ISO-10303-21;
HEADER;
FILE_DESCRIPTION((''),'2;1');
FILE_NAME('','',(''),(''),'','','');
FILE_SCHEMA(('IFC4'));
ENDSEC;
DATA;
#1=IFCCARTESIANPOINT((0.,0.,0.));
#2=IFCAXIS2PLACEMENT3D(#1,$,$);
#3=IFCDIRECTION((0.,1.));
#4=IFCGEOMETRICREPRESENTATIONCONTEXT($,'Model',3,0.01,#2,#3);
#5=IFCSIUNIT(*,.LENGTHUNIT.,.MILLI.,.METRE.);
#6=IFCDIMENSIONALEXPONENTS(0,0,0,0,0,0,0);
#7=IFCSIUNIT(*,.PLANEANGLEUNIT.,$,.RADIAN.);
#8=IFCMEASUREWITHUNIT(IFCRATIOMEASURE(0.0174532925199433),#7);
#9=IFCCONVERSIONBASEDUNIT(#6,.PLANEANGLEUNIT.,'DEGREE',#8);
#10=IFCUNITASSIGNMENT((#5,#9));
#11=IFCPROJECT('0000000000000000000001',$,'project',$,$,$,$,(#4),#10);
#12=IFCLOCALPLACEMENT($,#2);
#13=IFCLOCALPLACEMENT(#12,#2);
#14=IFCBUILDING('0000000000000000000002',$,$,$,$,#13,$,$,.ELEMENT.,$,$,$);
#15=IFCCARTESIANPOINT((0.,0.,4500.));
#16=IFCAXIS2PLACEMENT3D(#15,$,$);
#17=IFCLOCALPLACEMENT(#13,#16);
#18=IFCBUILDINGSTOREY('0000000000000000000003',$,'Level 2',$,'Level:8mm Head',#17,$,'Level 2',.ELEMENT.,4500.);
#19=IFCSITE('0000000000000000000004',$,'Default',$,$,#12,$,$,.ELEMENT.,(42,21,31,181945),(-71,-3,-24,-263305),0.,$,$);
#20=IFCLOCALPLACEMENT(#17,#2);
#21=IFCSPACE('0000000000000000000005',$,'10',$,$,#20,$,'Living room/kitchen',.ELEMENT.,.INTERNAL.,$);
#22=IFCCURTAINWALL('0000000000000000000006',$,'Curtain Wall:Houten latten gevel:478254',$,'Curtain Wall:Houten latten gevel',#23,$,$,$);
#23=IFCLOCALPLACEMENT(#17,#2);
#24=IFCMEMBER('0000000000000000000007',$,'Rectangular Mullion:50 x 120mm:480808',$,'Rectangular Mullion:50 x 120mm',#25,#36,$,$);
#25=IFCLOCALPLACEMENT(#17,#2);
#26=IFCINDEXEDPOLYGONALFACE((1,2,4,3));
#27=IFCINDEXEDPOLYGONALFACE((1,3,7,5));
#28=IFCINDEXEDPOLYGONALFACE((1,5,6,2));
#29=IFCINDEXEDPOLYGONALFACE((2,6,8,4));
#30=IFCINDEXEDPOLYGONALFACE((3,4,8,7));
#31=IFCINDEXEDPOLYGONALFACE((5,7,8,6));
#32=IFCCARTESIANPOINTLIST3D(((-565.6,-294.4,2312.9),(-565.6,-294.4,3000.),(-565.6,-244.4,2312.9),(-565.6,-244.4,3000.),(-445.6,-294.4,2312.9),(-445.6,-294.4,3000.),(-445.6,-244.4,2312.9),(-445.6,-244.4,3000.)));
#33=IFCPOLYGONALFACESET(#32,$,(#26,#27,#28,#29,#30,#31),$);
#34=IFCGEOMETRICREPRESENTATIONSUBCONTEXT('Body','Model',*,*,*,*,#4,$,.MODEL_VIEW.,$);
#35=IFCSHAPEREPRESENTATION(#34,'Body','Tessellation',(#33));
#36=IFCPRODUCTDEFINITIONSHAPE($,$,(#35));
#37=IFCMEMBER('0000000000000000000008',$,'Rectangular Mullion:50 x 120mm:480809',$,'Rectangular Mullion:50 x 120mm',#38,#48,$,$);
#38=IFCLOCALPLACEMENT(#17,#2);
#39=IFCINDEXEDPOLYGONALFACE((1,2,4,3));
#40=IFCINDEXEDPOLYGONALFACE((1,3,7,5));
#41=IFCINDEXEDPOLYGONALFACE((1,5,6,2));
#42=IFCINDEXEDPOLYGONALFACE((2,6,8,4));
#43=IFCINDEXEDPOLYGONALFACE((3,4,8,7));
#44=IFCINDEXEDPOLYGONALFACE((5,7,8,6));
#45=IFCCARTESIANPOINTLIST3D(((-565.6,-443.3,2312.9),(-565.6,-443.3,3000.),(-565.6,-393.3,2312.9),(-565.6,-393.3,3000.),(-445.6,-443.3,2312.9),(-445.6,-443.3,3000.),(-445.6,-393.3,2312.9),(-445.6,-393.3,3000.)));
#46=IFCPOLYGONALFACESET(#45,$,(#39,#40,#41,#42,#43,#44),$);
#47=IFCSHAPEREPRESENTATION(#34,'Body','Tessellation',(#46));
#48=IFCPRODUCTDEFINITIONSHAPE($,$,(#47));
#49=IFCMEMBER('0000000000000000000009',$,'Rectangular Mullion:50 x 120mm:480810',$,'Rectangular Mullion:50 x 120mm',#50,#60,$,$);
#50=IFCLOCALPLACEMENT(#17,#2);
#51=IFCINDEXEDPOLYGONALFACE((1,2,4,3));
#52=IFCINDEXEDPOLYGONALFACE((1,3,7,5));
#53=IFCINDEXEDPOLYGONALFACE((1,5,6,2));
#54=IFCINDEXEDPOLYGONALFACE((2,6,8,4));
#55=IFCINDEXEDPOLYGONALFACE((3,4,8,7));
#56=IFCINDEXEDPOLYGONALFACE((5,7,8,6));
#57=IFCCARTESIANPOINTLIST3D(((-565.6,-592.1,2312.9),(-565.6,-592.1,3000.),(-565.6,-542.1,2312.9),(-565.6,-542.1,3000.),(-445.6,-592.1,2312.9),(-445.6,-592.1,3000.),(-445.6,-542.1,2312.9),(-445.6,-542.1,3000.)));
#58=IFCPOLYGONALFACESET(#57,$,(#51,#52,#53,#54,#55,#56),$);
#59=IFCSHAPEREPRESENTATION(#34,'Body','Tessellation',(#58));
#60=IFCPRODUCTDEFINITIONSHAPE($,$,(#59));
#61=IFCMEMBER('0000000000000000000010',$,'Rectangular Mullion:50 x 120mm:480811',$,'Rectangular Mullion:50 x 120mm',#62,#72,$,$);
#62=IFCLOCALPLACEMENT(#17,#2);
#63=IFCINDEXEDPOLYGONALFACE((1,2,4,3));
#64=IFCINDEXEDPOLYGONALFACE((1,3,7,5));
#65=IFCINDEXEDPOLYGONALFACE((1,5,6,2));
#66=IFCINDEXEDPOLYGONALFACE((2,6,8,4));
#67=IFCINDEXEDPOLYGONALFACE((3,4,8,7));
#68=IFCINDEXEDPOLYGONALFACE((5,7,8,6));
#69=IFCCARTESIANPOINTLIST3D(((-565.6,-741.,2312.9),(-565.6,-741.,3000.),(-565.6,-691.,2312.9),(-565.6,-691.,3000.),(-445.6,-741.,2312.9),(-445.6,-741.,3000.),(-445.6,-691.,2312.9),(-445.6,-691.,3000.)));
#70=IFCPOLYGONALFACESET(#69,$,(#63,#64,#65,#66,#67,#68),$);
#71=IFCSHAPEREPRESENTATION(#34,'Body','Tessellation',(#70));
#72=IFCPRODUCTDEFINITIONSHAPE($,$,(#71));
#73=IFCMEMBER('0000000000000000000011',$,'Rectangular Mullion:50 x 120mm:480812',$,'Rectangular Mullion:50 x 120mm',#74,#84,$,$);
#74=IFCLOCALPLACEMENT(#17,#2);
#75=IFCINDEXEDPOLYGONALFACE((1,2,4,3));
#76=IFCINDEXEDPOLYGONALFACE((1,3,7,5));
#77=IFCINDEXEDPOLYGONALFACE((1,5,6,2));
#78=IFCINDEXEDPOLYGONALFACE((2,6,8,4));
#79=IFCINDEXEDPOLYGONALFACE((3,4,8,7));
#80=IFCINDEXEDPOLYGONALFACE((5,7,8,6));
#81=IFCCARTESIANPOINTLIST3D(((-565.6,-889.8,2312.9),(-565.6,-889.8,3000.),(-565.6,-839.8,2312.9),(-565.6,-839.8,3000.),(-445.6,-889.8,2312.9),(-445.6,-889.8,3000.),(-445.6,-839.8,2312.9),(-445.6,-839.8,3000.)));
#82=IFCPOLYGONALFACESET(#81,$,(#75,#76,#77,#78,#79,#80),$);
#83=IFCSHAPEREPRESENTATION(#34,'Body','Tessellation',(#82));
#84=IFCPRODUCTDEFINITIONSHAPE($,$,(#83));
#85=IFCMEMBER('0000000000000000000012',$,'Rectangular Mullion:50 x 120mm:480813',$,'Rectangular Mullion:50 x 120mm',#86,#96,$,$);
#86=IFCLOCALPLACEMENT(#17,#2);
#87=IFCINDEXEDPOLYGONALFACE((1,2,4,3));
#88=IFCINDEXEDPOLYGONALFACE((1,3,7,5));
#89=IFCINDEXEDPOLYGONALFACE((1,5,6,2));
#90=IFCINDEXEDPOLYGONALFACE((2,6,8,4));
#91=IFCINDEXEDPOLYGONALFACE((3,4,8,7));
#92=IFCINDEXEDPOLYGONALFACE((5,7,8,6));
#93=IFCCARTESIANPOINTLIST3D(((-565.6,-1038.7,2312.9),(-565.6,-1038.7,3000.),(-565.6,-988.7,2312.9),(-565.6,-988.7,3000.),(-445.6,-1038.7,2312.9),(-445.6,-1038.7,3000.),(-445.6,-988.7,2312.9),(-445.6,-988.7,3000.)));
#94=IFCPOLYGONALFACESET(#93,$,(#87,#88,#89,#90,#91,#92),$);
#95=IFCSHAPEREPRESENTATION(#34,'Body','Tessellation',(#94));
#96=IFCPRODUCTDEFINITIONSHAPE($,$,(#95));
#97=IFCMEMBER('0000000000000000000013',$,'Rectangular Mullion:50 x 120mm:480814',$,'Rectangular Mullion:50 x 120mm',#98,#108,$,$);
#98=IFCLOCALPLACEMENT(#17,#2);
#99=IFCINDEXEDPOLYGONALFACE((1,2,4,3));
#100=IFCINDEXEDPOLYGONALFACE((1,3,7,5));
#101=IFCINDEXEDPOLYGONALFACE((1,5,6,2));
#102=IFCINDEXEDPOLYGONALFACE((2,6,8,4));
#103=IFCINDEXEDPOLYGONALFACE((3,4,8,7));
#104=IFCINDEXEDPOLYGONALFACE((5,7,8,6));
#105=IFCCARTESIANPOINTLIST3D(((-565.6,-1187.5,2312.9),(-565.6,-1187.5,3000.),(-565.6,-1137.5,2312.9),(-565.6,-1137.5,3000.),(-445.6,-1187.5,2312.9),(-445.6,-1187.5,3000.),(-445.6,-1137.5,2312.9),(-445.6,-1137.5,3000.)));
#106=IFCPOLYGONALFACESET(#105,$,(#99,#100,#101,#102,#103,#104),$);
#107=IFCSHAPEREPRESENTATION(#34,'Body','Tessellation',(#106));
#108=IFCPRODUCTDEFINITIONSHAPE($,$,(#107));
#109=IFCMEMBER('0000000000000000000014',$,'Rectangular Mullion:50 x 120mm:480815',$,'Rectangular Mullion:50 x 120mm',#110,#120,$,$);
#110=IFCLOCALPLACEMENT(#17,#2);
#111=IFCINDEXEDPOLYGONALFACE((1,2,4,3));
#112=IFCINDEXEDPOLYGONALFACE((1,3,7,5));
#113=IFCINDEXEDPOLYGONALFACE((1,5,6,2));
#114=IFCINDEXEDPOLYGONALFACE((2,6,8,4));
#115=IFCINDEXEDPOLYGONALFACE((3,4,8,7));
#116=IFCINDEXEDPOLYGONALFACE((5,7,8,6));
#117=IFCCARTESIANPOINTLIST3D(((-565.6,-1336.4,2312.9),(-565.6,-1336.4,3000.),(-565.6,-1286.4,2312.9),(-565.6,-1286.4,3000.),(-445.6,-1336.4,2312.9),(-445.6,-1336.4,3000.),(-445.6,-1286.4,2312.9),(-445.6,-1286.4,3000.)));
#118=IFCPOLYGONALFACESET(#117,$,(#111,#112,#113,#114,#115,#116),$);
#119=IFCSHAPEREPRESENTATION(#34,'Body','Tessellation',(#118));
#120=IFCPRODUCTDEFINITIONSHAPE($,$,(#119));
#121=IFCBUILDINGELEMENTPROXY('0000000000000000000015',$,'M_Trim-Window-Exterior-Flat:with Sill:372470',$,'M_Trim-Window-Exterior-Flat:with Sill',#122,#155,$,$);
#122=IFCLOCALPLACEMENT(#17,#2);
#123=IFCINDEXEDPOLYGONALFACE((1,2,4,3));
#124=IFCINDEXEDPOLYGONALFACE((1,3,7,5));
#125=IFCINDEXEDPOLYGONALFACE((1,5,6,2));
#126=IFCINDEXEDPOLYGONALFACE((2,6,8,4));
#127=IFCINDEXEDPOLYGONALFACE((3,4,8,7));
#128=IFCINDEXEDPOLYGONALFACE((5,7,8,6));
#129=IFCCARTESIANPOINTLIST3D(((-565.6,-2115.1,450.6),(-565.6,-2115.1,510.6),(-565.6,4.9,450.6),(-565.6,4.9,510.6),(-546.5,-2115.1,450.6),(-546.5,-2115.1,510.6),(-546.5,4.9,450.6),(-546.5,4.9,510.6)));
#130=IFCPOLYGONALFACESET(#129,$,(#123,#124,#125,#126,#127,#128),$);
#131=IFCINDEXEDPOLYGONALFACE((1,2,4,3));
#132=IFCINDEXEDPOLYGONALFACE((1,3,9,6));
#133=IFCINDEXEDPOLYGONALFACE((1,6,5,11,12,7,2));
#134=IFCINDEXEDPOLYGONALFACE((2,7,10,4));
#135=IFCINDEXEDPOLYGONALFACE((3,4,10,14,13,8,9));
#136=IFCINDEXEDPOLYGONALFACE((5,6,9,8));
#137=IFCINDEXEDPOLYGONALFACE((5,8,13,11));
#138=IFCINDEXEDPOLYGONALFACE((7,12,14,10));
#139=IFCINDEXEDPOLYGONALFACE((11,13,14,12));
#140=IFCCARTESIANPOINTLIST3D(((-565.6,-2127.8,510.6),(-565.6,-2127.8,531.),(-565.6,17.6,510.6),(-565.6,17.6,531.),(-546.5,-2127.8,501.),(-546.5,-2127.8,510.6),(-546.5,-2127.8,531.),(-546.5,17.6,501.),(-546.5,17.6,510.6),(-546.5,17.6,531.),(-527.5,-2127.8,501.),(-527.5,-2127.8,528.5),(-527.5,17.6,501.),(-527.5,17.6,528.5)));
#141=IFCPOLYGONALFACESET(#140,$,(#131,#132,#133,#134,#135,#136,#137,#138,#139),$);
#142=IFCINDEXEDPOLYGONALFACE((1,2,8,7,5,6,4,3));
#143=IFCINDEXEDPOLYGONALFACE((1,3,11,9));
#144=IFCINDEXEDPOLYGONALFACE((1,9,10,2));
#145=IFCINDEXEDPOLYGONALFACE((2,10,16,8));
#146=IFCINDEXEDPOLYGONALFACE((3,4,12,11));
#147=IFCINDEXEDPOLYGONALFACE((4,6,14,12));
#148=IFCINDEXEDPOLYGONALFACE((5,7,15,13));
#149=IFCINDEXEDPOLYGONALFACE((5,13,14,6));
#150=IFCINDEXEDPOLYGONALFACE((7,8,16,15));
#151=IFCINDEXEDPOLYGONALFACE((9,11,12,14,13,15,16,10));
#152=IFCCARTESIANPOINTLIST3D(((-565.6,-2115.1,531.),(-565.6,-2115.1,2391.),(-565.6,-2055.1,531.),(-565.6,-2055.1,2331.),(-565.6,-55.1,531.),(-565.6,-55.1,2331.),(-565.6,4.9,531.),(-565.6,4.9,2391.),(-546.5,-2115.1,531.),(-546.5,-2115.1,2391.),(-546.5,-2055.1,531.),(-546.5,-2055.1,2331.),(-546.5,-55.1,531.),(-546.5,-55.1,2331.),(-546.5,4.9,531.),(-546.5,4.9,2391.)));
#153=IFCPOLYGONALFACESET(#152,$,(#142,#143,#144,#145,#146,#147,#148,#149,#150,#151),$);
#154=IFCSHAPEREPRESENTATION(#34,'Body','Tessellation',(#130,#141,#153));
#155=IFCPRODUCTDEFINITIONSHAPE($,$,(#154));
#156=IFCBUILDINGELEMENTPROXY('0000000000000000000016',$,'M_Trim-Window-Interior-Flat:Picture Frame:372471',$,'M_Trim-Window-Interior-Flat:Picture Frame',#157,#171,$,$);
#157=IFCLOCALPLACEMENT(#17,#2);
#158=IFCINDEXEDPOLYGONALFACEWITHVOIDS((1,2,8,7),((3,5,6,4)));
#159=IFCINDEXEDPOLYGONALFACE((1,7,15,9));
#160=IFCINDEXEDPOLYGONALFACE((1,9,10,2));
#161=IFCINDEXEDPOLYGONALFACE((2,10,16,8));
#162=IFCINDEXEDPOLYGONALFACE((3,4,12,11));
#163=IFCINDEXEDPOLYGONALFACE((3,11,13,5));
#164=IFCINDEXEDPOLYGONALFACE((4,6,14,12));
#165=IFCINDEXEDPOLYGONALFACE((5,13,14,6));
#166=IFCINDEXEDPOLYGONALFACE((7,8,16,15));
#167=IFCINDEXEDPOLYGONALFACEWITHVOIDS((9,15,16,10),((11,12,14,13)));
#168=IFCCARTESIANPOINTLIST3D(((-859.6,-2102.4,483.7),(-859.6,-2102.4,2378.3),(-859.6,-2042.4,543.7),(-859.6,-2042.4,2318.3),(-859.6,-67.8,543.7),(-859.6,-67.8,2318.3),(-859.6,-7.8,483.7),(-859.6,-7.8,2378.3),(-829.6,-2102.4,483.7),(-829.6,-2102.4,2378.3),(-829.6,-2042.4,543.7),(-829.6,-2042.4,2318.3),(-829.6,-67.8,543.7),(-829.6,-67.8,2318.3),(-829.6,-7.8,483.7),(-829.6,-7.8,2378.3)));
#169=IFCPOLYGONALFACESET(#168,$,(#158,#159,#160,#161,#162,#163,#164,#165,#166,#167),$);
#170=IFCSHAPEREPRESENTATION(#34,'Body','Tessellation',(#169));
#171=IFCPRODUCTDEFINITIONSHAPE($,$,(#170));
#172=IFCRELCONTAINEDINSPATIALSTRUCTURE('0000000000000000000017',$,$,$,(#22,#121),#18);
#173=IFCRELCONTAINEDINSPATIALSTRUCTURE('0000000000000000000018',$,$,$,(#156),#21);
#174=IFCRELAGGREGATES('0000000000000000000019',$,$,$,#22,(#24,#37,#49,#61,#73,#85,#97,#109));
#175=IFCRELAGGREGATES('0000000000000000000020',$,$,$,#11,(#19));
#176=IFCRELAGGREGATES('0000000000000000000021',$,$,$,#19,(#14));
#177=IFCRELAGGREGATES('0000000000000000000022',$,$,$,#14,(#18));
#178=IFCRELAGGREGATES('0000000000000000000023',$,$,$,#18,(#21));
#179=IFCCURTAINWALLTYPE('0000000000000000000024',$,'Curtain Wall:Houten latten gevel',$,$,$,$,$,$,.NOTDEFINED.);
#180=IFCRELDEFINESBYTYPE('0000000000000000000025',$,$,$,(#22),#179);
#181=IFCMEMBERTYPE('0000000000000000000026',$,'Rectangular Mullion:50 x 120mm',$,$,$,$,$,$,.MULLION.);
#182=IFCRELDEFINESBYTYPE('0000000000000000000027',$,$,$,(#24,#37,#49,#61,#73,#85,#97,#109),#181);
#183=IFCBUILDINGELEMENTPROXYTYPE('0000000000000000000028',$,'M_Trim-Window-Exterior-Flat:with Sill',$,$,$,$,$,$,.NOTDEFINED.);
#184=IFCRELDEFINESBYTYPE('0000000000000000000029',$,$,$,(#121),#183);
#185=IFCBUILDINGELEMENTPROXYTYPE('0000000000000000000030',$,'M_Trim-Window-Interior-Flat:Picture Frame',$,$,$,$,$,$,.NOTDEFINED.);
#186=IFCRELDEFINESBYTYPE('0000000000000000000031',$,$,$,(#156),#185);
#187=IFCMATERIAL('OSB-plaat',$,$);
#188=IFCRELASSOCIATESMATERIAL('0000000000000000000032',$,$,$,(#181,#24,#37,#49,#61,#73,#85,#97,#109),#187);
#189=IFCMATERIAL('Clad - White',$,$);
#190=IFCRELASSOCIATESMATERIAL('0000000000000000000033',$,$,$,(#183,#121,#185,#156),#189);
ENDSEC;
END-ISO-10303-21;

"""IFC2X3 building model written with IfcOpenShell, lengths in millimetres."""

from ifc_helpers import new_model, entity, si_unit, converted_unit, direction, frame, frame_2d, origin, origin_2d_with_axis, place, context, subcontext, project, spatial, polyline, rectangle, outline, extrude, source, transform, mapped, material, type_object, type_shapes, element, aggregate, save


model = new_model("IFC2X3")

# Units and contexts
model_context = context("Model", 3, precision=0.01, world=origin(), true_north=direction((0.0, 1.0)))
body_context = subcontext(model_context, "Body", "Model", "MODEL_VIEW")
ifc_project = project(units=[si_unit("LENGTHUNIT", "METRE", prefix="MILLI"), converted_unit("PLANEANGLEUNIT", "DEGREE", entity("IfcRatioMeasure", 0.0174532925199433), si_unit("PLANEANGLEUNIT", "RADIAN"), dimensions=[0, 0, 0, 0, 0, 0, 0])], contexts=[model_context])

# Site, building, storey
site_placement = place(None, frame((0.0, 0.0, 0.0)))
site = spatial("IfcSite", under=ifc_project, at=site_placement, Name="Default", CompositionType="ELEMENT", RefLatitude=(42, 21, 31, 181945), RefLongitude=(-71, -3, -24, -263305), RefElevation=0.0)
building_placement = place(site_placement, origin())
building = spatial("IfcBuilding", under=site, at=building_placement, CompositionType="ELEMENT")
storey_placement = place(building_placement, frame((0.0, 0.0, 4500.0)))
storey = spatial("IfcBuildingStorey", under=building, at=storey_placement, Name="Level 2", ObjectType="Level:8mm Head", LongName="Level 2", CompositionType="ELEMENT", Elevation=4500.0)

# Curtain wall, members
curtain_wall_type = type_object("IfcCurtainWallType", Name="Curtain Wall:Houten latten gevel", PredefinedType="NOTDEFINED")
curtain_wall_placement = place(storey_placement, frame((0.0, 0.0, -4500.0)))
curtain_wall = element("IfcCurtainWall", 1, at=curtain_wall_placement, inside=storey, type_object=curtain_wall_type, Name="Curtain Wall:Houten latten gevel:478254", ObjectType="Curtain Wall:Houten latten gevel")
ifc_material_1 = material(Name="OSB-plaat")
member_type_1 = type_object("IfcMemberType", Name="Rectangular Mullion:50 x 120mm", PredefinedType="MULLION", material=ifc_material_1)
shared_shape_1 = source(origin(), body_context, "Body", "SweptSolid", [
    extrude(rectangle(XDim=120.0, YDim=50.0, at=origin_2d_with_axis()), frame((0.0, 0.0, -687.1), z_axis=(0.0, 0.0, 1.0), x_axis=(0.0, -1.0, 0.0)), (0.0, 0.0, 1.0), 687.1),
])
type_shapes(member_type_1, [shared_shape_1])
member_1_placement = place(storey_placement, frame((-505.6, -269.4, 2312.9), z_axis=(0.0, 0.0, -1.0), x_axis=(0.0, -1.0, 0.0)))
member_1 = element("IfcMember", 2, at=member_1_placement, type_object=member_type_1, material=ifc_material_1, Name="Rectangular Mullion:50 x 120mm:480808", ObjectType="Rectangular Mullion:50 x 120mm", context=body_context, shape_type="MappedRepresentation", body=[
    mapped(shared_shape_1, transform((0.0, 0.0, 0.0), scale=1.0)),
])
member_2_placement = place(storey_placement, frame((-505.6, -418.3, 2312.9), z_axis=(0.0, 0.0, -1.0), x_axis=(0.0, -1.0, 0.0)))
member_2 = element("IfcMember", 3, at=member_2_placement, type_object=member_type_1, material=ifc_material_1, Name="Rectangular Mullion:50 x 120mm:480809", ObjectType="Rectangular Mullion:50 x 120mm", context=body_context, shape_type="MappedRepresentation", body=[
    mapped(shared_shape_1, transform((0.0, 0.0, 0.0), scale=1.0)),
])
member_3_placement = place(storey_placement, frame((-505.6, -567.1, 2312.9), z_axis=(0.0, 0.0, -1.0), x_axis=(0.0, -1.0, 0.0)))
member_3 = element("IfcMember", 4, at=member_3_placement, type_object=member_type_1, material=ifc_material_1, Name="Rectangular Mullion:50 x 120mm:480810", ObjectType="Rectangular Mullion:50 x 120mm", context=body_context, shape_type="MappedRepresentation", body=[
    mapped(shared_shape_1, transform((0.0, 0.0, 0.0), scale=1.0)),
])
member_4_placement = place(storey_placement, frame((-505.6, -716.0, 2312.9), z_axis=(0.0, 0.0, -1.0), x_axis=(0.0, -1.0, 0.0)))
member_4 = element("IfcMember", 5, at=member_4_placement, type_object=member_type_1, material=ifc_material_1, Name="Rectangular Mullion:50 x 120mm:480811", ObjectType="Rectangular Mullion:50 x 120mm", context=body_context, shape_type="MappedRepresentation", body=[
    mapped(shared_shape_1, transform((0.0, 0.0, 0.0), scale=1.0)),
])
member_5_placement = place(storey_placement, frame((-505.6, -864.8, 2312.9), z_axis=(0.0, 0.0, -1.0), x_axis=(0.0, -1.0, 0.0)))
member_5 = element("IfcMember", 6, at=member_5_placement, type_object=member_type_1, material=ifc_material_1, Name="Rectangular Mullion:50 x 120mm:480812", ObjectType="Rectangular Mullion:50 x 120mm", context=body_context, shape_type="MappedRepresentation", body=[
    mapped(shared_shape_1, transform((0.0, 0.0, 0.0), scale=1.0)),
])
member_6_placement = place(storey_placement, frame((-505.6, -1013.7, 2312.9), z_axis=(0.0, 0.0, -1.0), x_axis=(0.0, -1.0, 0.0)))
member_6 = element("IfcMember", 7, at=member_6_placement, type_object=member_type_1, material=ifc_material_1, Name="Rectangular Mullion:50 x 120mm:480813", ObjectType="Rectangular Mullion:50 x 120mm", context=body_context, shape_type="MappedRepresentation", body=[
    mapped(shared_shape_1, transform((0.0, 0.0, 0.0), scale=1.0)),
])
member_7_placement = place(storey_placement, frame((-505.6, -1162.5, 2312.9), z_axis=(0.0, 0.0, -1.0), x_axis=(0.0, -1.0, 0.0)))
member_7 = element("IfcMember", 8, at=member_7_placement, type_object=member_type_1, material=ifc_material_1, Name="Rectangular Mullion:50 x 120mm:480814", ObjectType="Rectangular Mullion:50 x 120mm", context=body_context, shape_type="MappedRepresentation", body=[
    mapped(shared_shape_1, transform((0.0, 0.0, 0.0), scale=1.0)),
])
member_8_placement = place(storey_placement, frame((-505.6, -1311.4, 2312.9), z_axis=(0.0, 0.0, -1.0), x_axis=(0.0, -1.0, 0.0)))
member_8 = element("IfcMember", 9, at=member_8_placement, type_object=member_type_1, material=ifc_material_1, Name="Rectangular Mullion:50 x 120mm:480815", ObjectType="Rectangular Mullion:50 x 120mm", context=body_context, shape_type="MappedRepresentation", body=[
    mapped(shared_shape_1, transform((0.0, 0.0, 0.0), scale=1.0)),
])
aggregate(curtain_wall, [member_1, member_2, member_3, member_4, member_5, member_6, member_7, member_8])

# Building element proxy
ifc_material_2 = material(Name="Clad - White")
building_element_proxy_type_1 = type_object("IfcBuildingElementProxyType", Name="M_Trim-Window-Exterior-Flat:with Sill", PredefinedType="NOTDEFINED", material=ifc_material_2)
shared_shape_2 = source(origin(), body_context, "Body", "SweptSolid", [
    extrude(rectangle(XDim=2120.0, YDim=60.0, at=frame_2d((0.0, 0.0), x_axis=(1.0, 0.0))), frame((0.0, -1850.4, 0.0), z_axis=(0.0, 0.0, 1.0), x_axis=(-1.0, 0.0, 0.0)), (0.0, 0.0, 1.0), 19.1),
    extrude(outline(polyline([(-19.0, -15.2), (0.0, -15.2), (0.0, -5.7), (19.0, -5.7), (19.0, 14.8), (0.0, 14.8), (-19.0, 12.3), (-19.0, -15.2)])), frame((-1072.7, -1814.8, 19.0), z_axis=(1.0, 0.0, 0.0), x_axis=(0.0, 0.0, -1.0)), (0.0, 0.0, 1.0), 2145.4),
    extrude(outline(polyline([(-945.0, -1060.0), (915.0, -1060.0), (915.0, -1000.0), (-885.0, -1000.0), (-885.0, 1000.0), (915.0, 1000.0), (915.0, 1060.0), (-945.0, 1060.0), (-945.0, -1060.0)])), frame((0.0, -885.0, 0.0), z_axis=(0.0, 0.0, 1.0), x_axis=(0.0, -1.0, 0.0)), (0.0, 0.0, 1.0), 19.1),
])
type_shapes(building_element_proxy_type_1, [shared_shape_2])
proxy_1_placement = place(storey_placement, frame((-565.6, -1055.1, 2331.0), z_axis=(1.0, 0.0, 0.0), x_axis=(0.0, 1.0, 0.0)))
element("IfcBuildingElementProxy", 10, at=proxy_1_placement, inside=storey, type_object=building_element_proxy_type_1, material=ifc_material_2, Name="M_Trim-Window-Exterior-Flat:with Sill:372470", ObjectType="M_Trim-Window-Exterior-Flat:with Sill", context=body_context, shape_type="MappedRepresentation", body=[
    mapped(shared_shape_2, transform((0.0, 0.0, 0.0), scale=1.0)),
])

# Shared definitions
space_placement = place(storey_placement, origin())
space = spatial("IfcSpace", under=storey, at=space_placement, Name="10", LongName="Living room/kitchen", CompositionType="ELEMENT", InteriorOrExteriorSpace="INTERNAL")

# Building element proxy
building_element_proxy_type_2 = type_object("IfcBuildingElementProxyType", Name="M_Trim-Window-Interior-Flat:Picture Frame", PredefinedType="NOTDEFINED", material=ifc_material_2)
shared_shape_3 = source(origin(), body_context, "Body", "SweptSolid", [
    extrude(outline(polyline([(-1047.3, -947.3), (1047.3, -947.3), (1047.3, 947.3), (-1047.3, 947.3), (-1047.3, -947.3)]), holes=[polyline([(-987.3, -887.3), (-987.3, 887.3), (987.3, 887.3), (987.3, -887.3), (-987.3, -887.3)])]), frame((0.0, -900.0, 0.0), z_axis=(0.0, 0.0, 1.0), x_axis=(-1.0, 0.0, 0.0)), (0.0, 0.0, 1.0), 30.0),
])
type_shapes(building_element_proxy_type_2, [shared_shape_3])
proxy_2_placement = place(space_placement, frame((-829.6, -1055.1, 2331.0), z_axis=(-1.0, 0.0, 0.0), x_axis=(0.0, -1.0, 0.0)))
element("IfcBuildingElementProxy", 11, at=proxy_2_placement, inside=space, type_object=building_element_proxy_type_2, material=ifc_material_2, Name="M_Trim-Window-Interior-Flat:Picture Frame:372471", ObjectType="M_Trim-Window-Interior-Flat:Picture Frame", context=body_context, shape_type="MappedRepresentation", body=[
    mapped(shared_shape_3, transform((0.0, 0.0, 0.0), scale=1.0)),
])

save(model, "model.ifc")
